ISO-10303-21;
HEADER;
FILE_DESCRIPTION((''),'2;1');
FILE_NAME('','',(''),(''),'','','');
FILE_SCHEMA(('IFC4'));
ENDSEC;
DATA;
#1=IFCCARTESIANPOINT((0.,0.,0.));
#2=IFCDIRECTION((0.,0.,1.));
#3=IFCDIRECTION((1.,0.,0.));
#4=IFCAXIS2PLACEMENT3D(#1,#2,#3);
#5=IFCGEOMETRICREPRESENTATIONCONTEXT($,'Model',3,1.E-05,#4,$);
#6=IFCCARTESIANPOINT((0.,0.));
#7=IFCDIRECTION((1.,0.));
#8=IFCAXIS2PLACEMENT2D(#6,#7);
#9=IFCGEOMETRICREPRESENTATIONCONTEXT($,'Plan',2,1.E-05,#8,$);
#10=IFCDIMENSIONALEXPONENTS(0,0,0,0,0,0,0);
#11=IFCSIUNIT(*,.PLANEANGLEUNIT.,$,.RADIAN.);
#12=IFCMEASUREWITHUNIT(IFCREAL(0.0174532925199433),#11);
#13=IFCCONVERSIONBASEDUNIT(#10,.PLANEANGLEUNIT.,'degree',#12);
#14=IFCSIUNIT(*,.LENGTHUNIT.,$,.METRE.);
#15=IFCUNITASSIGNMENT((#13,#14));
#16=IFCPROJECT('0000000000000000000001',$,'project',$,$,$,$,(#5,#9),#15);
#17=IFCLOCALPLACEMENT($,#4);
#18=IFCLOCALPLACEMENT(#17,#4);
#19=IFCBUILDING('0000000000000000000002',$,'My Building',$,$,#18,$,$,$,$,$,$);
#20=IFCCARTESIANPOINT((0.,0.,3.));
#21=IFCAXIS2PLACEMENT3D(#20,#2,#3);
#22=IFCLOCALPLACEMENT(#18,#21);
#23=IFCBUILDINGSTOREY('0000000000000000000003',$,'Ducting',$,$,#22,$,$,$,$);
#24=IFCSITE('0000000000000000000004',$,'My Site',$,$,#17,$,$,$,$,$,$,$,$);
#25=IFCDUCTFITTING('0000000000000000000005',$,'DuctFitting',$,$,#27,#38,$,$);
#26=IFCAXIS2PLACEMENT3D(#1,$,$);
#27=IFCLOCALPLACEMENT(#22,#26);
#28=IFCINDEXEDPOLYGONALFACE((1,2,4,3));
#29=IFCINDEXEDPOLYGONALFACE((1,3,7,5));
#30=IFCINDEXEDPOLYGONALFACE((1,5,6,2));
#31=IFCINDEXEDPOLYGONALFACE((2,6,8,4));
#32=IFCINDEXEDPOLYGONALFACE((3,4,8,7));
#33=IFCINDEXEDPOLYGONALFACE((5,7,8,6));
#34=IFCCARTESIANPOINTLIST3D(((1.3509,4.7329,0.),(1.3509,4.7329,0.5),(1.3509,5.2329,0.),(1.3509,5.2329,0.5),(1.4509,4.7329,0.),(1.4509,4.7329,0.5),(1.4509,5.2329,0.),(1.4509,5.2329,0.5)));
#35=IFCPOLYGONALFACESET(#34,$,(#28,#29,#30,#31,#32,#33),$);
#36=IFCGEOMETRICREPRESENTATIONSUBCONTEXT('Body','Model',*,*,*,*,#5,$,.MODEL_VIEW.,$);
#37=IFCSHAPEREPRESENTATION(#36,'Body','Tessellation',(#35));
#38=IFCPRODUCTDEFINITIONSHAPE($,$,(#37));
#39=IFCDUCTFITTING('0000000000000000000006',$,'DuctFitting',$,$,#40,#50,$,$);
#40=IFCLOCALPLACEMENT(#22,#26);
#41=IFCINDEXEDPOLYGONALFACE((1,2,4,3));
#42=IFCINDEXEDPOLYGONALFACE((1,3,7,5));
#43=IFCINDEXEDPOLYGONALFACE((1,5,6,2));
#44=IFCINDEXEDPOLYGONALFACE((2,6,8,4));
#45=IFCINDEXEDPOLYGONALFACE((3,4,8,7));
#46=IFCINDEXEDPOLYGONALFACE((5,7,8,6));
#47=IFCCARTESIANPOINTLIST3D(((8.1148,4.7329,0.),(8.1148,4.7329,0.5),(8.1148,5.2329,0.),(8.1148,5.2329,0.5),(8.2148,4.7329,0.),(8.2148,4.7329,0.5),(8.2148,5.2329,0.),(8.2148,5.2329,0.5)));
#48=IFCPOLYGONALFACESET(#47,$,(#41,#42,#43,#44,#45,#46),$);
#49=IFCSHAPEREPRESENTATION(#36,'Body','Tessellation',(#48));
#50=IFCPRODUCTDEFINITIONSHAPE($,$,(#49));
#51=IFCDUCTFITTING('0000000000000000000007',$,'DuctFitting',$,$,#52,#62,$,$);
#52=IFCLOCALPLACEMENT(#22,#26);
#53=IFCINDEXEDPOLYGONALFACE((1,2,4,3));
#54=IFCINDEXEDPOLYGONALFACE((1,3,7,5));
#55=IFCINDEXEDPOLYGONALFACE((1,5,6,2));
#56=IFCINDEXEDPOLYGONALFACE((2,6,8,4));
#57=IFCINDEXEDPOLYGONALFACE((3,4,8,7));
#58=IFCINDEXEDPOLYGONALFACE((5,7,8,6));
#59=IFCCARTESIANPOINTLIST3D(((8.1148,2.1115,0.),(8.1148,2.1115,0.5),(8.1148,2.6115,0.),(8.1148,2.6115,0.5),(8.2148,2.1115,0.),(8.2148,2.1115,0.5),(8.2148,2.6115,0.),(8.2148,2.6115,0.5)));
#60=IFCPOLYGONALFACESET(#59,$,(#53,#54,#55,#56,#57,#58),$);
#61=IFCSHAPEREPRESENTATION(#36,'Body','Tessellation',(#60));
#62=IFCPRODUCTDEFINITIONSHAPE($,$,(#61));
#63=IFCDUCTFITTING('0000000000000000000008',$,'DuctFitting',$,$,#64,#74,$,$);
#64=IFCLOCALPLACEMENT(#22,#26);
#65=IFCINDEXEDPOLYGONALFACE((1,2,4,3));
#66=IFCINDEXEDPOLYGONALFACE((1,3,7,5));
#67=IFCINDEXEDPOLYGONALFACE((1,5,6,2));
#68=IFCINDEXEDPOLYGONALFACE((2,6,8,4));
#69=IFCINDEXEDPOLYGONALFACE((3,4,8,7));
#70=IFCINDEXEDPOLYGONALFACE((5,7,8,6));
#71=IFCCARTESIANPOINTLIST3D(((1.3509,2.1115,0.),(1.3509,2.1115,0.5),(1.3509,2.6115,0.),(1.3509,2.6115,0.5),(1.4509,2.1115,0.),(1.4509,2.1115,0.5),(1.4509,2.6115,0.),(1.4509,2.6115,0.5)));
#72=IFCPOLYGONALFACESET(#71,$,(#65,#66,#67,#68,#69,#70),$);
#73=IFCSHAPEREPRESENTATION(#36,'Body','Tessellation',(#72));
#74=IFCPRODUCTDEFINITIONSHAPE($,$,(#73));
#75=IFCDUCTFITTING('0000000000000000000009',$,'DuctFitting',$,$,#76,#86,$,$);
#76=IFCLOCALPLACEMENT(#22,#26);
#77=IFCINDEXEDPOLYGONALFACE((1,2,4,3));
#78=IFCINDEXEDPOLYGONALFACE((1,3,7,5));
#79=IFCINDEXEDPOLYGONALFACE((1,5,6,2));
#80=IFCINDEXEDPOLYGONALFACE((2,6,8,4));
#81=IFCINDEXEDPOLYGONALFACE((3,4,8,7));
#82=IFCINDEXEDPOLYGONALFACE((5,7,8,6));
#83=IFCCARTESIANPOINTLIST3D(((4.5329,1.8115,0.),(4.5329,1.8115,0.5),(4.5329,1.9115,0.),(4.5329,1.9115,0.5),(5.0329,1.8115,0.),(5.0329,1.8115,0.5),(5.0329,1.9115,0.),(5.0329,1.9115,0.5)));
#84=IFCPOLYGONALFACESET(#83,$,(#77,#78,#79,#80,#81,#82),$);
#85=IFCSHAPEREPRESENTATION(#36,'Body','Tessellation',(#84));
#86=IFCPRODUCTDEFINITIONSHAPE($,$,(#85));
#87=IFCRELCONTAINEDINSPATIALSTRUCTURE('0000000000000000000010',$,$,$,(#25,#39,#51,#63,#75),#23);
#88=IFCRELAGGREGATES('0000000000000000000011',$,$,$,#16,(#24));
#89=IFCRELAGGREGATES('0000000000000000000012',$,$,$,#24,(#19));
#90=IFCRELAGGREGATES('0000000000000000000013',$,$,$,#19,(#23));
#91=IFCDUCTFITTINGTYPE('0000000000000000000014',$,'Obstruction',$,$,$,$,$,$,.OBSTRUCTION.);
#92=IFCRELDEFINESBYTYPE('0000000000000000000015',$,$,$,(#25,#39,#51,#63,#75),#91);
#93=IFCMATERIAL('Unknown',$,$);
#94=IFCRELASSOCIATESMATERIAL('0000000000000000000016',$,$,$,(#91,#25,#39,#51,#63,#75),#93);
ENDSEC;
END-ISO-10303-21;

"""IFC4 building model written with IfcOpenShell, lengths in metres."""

from ifc_helpers import new_model, entity, si_unit, converted_unit, frame, origin_with_axes, origin_2d_with_axis, place, context, subcontext, project, spatial, rectangle, extrude, material, material_profile, profile_set, profile_usage, type_object, element, save


model = new_model("IFC4")

# Units and contexts
model_context = context("Model", 3, precision=1e-05, world=origin_with_axes())
plan_context = context("Plan", 2, precision=1e-05, world=origin_2d_with_axis())
body_context = subcontext(model_context, "Body", "Model", "MODEL_VIEW")
ifc_project = project(units=[converted_unit("PLANEANGLEUNIT", "degree", entity("IfcReal", 0.0174532925199433), si_unit("PLANEANGLEUNIT", "RADIAN"), dimensions=[0, 0, 0, 0, 0, 0, 0]), si_unit("LENGTHUNIT", "METRE")], contexts=[model_context, plan_context])

# Site, building, storey
site_placement = place(None, origin_with_axes())
site = spatial("IfcSite", under=ifc_project, at=site_placement, Name="My Site")
building_placement = place(site_placement, origin_with_axes())
building = spatial("IfcBuilding", under=site, at=building_placement, Name="My Building")
storey_placement = place(building_placement, frame((0.0, 0.0, 3.0), z_axis=(0.0, 0.0, 1.0), x_axis=(1.0, 0.0, 0.0)))
storey = spatial("IfcBuildingStorey", under=building, at=storey_placement, Name="Ducting")

# Shared definitions
ifc_material = material(Name="Unknown")

# Duct fittings
ifc_material_profile_1 = material_profile(ifc_material, rectangle(XDim=0.5, YDim=0.5))
ifc_profile_set_1 = profile_set([ifc_material_profile_1])
ifc_profile_usage_1 = profile_usage(ifc_profile_set_1, cardinal=5)
duct_fitting_type_1 = type_object("IfcDuctFittingType", Name="Obstruction", PredefinedType="OBSTRUCTION", material=ifc_profile_set_1)
duct_fitting_1_placement = place(storey_placement, frame((1.4509, 4.9829, 0.25), z_axis=(-1.0, 0.0, 0.0), x_axis=(0.0, -1.0, 0.0)))
element("IfcDuctFitting", 1, at=duct_fitting_1_placement, inside=storey, type_object=duct_fitting_type_1, material=ifc_profile_usage_1, Name="DuctFitting", context=body_context, shape_type="SweptSolid", body=[
    extrude(rectangle(XDim=0.5, YDim=0.5), origin_with_axes(), (0.0, 0.0, 1.0), 0.1),
])
ifc_profile_usage_2 = profile_usage(ifc_profile_set_1, cardinal=5)
duct_fitting_2_placement = place(storey_placement, frame((8.1148, 4.9829, 0.25), z_axis=(1.0, 0.0, 0.0), x_axis=(0.0, 1.0, 0.0)))
element("IfcDuctFitting", 2, at=duct_fitting_2_placement, inside=storey, type_object=duct_fitting_type_1, material=ifc_profile_usage_2, Name="DuctFitting", context=body_context, shape_type="SweptSolid", body=[
    extrude(rectangle(XDim=0.5, YDim=0.5), origin_with_axes(), (0.0, 0.0, 1.0), 0.1),
])
ifc_profile_usage_3 = profile_usage(ifc_profile_set_1, cardinal=5)
duct_fitting_3_placement = place(storey_placement, frame((8.1148, 2.3615, 0.25), z_axis=(1.0, 0.0, 0.0), x_axis=(0.0, 1.0, 0.0)))
element("IfcDuctFitting", 3, at=duct_fitting_3_placement, inside=storey, type_object=duct_fitting_type_1, material=ifc_profile_usage_3, Name="DuctFitting", context=body_context, shape_type="SweptSolid", body=[
    extrude(rectangle(XDim=0.5, YDim=0.5), origin_with_axes(), (0.0, 0.0, 1.0), 0.1),
])
ifc_profile_usage_4 = profile_usage(ifc_profile_set_1, cardinal=5)
duct_fitting_4_placement = place(storey_placement, frame((1.4509, 2.3615, 0.25), z_axis=(-1.0, 0.0, 0.0), x_axis=(0.0, -1.0, 0.0)))
element("IfcDuctFitting", 4, at=duct_fitting_4_placement, inside=storey, type_object=duct_fitting_type_1, material=ifc_profile_usage_4, Name="DuctFitting", context=body_context, shape_type="SweptSolid", body=[
    extrude(rectangle(XDim=0.5, YDim=0.5), origin_with_axes(), (0.0, 0.0, 1.0), 0.1),
])
ifc_profile_usage_5 = profile_usage(ifc_profile_set_1, cardinal=5)
duct_fitting_5_placement = place(storey_placement, frame((4.7829, 1.9115, 0.25), z_axis=(0.0, -1.0, 0.0), x_axis=(1.0, 0.0, 0.0)))
element("IfcDuctFitting", 5, at=duct_fitting_5_placement, inside=storey, type_object=duct_fitting_type_1, material=ifc_profile_usage_5, Name="DuctFitting", context=body_context, shape_type="SweptSolid", body=[
    extrude(rectangle(XDim=0.5, YDim=0.5), origin_with_axes(), (0.0, 0.0, 1.0), 0.1),
])

save(model, "model.ifc")
